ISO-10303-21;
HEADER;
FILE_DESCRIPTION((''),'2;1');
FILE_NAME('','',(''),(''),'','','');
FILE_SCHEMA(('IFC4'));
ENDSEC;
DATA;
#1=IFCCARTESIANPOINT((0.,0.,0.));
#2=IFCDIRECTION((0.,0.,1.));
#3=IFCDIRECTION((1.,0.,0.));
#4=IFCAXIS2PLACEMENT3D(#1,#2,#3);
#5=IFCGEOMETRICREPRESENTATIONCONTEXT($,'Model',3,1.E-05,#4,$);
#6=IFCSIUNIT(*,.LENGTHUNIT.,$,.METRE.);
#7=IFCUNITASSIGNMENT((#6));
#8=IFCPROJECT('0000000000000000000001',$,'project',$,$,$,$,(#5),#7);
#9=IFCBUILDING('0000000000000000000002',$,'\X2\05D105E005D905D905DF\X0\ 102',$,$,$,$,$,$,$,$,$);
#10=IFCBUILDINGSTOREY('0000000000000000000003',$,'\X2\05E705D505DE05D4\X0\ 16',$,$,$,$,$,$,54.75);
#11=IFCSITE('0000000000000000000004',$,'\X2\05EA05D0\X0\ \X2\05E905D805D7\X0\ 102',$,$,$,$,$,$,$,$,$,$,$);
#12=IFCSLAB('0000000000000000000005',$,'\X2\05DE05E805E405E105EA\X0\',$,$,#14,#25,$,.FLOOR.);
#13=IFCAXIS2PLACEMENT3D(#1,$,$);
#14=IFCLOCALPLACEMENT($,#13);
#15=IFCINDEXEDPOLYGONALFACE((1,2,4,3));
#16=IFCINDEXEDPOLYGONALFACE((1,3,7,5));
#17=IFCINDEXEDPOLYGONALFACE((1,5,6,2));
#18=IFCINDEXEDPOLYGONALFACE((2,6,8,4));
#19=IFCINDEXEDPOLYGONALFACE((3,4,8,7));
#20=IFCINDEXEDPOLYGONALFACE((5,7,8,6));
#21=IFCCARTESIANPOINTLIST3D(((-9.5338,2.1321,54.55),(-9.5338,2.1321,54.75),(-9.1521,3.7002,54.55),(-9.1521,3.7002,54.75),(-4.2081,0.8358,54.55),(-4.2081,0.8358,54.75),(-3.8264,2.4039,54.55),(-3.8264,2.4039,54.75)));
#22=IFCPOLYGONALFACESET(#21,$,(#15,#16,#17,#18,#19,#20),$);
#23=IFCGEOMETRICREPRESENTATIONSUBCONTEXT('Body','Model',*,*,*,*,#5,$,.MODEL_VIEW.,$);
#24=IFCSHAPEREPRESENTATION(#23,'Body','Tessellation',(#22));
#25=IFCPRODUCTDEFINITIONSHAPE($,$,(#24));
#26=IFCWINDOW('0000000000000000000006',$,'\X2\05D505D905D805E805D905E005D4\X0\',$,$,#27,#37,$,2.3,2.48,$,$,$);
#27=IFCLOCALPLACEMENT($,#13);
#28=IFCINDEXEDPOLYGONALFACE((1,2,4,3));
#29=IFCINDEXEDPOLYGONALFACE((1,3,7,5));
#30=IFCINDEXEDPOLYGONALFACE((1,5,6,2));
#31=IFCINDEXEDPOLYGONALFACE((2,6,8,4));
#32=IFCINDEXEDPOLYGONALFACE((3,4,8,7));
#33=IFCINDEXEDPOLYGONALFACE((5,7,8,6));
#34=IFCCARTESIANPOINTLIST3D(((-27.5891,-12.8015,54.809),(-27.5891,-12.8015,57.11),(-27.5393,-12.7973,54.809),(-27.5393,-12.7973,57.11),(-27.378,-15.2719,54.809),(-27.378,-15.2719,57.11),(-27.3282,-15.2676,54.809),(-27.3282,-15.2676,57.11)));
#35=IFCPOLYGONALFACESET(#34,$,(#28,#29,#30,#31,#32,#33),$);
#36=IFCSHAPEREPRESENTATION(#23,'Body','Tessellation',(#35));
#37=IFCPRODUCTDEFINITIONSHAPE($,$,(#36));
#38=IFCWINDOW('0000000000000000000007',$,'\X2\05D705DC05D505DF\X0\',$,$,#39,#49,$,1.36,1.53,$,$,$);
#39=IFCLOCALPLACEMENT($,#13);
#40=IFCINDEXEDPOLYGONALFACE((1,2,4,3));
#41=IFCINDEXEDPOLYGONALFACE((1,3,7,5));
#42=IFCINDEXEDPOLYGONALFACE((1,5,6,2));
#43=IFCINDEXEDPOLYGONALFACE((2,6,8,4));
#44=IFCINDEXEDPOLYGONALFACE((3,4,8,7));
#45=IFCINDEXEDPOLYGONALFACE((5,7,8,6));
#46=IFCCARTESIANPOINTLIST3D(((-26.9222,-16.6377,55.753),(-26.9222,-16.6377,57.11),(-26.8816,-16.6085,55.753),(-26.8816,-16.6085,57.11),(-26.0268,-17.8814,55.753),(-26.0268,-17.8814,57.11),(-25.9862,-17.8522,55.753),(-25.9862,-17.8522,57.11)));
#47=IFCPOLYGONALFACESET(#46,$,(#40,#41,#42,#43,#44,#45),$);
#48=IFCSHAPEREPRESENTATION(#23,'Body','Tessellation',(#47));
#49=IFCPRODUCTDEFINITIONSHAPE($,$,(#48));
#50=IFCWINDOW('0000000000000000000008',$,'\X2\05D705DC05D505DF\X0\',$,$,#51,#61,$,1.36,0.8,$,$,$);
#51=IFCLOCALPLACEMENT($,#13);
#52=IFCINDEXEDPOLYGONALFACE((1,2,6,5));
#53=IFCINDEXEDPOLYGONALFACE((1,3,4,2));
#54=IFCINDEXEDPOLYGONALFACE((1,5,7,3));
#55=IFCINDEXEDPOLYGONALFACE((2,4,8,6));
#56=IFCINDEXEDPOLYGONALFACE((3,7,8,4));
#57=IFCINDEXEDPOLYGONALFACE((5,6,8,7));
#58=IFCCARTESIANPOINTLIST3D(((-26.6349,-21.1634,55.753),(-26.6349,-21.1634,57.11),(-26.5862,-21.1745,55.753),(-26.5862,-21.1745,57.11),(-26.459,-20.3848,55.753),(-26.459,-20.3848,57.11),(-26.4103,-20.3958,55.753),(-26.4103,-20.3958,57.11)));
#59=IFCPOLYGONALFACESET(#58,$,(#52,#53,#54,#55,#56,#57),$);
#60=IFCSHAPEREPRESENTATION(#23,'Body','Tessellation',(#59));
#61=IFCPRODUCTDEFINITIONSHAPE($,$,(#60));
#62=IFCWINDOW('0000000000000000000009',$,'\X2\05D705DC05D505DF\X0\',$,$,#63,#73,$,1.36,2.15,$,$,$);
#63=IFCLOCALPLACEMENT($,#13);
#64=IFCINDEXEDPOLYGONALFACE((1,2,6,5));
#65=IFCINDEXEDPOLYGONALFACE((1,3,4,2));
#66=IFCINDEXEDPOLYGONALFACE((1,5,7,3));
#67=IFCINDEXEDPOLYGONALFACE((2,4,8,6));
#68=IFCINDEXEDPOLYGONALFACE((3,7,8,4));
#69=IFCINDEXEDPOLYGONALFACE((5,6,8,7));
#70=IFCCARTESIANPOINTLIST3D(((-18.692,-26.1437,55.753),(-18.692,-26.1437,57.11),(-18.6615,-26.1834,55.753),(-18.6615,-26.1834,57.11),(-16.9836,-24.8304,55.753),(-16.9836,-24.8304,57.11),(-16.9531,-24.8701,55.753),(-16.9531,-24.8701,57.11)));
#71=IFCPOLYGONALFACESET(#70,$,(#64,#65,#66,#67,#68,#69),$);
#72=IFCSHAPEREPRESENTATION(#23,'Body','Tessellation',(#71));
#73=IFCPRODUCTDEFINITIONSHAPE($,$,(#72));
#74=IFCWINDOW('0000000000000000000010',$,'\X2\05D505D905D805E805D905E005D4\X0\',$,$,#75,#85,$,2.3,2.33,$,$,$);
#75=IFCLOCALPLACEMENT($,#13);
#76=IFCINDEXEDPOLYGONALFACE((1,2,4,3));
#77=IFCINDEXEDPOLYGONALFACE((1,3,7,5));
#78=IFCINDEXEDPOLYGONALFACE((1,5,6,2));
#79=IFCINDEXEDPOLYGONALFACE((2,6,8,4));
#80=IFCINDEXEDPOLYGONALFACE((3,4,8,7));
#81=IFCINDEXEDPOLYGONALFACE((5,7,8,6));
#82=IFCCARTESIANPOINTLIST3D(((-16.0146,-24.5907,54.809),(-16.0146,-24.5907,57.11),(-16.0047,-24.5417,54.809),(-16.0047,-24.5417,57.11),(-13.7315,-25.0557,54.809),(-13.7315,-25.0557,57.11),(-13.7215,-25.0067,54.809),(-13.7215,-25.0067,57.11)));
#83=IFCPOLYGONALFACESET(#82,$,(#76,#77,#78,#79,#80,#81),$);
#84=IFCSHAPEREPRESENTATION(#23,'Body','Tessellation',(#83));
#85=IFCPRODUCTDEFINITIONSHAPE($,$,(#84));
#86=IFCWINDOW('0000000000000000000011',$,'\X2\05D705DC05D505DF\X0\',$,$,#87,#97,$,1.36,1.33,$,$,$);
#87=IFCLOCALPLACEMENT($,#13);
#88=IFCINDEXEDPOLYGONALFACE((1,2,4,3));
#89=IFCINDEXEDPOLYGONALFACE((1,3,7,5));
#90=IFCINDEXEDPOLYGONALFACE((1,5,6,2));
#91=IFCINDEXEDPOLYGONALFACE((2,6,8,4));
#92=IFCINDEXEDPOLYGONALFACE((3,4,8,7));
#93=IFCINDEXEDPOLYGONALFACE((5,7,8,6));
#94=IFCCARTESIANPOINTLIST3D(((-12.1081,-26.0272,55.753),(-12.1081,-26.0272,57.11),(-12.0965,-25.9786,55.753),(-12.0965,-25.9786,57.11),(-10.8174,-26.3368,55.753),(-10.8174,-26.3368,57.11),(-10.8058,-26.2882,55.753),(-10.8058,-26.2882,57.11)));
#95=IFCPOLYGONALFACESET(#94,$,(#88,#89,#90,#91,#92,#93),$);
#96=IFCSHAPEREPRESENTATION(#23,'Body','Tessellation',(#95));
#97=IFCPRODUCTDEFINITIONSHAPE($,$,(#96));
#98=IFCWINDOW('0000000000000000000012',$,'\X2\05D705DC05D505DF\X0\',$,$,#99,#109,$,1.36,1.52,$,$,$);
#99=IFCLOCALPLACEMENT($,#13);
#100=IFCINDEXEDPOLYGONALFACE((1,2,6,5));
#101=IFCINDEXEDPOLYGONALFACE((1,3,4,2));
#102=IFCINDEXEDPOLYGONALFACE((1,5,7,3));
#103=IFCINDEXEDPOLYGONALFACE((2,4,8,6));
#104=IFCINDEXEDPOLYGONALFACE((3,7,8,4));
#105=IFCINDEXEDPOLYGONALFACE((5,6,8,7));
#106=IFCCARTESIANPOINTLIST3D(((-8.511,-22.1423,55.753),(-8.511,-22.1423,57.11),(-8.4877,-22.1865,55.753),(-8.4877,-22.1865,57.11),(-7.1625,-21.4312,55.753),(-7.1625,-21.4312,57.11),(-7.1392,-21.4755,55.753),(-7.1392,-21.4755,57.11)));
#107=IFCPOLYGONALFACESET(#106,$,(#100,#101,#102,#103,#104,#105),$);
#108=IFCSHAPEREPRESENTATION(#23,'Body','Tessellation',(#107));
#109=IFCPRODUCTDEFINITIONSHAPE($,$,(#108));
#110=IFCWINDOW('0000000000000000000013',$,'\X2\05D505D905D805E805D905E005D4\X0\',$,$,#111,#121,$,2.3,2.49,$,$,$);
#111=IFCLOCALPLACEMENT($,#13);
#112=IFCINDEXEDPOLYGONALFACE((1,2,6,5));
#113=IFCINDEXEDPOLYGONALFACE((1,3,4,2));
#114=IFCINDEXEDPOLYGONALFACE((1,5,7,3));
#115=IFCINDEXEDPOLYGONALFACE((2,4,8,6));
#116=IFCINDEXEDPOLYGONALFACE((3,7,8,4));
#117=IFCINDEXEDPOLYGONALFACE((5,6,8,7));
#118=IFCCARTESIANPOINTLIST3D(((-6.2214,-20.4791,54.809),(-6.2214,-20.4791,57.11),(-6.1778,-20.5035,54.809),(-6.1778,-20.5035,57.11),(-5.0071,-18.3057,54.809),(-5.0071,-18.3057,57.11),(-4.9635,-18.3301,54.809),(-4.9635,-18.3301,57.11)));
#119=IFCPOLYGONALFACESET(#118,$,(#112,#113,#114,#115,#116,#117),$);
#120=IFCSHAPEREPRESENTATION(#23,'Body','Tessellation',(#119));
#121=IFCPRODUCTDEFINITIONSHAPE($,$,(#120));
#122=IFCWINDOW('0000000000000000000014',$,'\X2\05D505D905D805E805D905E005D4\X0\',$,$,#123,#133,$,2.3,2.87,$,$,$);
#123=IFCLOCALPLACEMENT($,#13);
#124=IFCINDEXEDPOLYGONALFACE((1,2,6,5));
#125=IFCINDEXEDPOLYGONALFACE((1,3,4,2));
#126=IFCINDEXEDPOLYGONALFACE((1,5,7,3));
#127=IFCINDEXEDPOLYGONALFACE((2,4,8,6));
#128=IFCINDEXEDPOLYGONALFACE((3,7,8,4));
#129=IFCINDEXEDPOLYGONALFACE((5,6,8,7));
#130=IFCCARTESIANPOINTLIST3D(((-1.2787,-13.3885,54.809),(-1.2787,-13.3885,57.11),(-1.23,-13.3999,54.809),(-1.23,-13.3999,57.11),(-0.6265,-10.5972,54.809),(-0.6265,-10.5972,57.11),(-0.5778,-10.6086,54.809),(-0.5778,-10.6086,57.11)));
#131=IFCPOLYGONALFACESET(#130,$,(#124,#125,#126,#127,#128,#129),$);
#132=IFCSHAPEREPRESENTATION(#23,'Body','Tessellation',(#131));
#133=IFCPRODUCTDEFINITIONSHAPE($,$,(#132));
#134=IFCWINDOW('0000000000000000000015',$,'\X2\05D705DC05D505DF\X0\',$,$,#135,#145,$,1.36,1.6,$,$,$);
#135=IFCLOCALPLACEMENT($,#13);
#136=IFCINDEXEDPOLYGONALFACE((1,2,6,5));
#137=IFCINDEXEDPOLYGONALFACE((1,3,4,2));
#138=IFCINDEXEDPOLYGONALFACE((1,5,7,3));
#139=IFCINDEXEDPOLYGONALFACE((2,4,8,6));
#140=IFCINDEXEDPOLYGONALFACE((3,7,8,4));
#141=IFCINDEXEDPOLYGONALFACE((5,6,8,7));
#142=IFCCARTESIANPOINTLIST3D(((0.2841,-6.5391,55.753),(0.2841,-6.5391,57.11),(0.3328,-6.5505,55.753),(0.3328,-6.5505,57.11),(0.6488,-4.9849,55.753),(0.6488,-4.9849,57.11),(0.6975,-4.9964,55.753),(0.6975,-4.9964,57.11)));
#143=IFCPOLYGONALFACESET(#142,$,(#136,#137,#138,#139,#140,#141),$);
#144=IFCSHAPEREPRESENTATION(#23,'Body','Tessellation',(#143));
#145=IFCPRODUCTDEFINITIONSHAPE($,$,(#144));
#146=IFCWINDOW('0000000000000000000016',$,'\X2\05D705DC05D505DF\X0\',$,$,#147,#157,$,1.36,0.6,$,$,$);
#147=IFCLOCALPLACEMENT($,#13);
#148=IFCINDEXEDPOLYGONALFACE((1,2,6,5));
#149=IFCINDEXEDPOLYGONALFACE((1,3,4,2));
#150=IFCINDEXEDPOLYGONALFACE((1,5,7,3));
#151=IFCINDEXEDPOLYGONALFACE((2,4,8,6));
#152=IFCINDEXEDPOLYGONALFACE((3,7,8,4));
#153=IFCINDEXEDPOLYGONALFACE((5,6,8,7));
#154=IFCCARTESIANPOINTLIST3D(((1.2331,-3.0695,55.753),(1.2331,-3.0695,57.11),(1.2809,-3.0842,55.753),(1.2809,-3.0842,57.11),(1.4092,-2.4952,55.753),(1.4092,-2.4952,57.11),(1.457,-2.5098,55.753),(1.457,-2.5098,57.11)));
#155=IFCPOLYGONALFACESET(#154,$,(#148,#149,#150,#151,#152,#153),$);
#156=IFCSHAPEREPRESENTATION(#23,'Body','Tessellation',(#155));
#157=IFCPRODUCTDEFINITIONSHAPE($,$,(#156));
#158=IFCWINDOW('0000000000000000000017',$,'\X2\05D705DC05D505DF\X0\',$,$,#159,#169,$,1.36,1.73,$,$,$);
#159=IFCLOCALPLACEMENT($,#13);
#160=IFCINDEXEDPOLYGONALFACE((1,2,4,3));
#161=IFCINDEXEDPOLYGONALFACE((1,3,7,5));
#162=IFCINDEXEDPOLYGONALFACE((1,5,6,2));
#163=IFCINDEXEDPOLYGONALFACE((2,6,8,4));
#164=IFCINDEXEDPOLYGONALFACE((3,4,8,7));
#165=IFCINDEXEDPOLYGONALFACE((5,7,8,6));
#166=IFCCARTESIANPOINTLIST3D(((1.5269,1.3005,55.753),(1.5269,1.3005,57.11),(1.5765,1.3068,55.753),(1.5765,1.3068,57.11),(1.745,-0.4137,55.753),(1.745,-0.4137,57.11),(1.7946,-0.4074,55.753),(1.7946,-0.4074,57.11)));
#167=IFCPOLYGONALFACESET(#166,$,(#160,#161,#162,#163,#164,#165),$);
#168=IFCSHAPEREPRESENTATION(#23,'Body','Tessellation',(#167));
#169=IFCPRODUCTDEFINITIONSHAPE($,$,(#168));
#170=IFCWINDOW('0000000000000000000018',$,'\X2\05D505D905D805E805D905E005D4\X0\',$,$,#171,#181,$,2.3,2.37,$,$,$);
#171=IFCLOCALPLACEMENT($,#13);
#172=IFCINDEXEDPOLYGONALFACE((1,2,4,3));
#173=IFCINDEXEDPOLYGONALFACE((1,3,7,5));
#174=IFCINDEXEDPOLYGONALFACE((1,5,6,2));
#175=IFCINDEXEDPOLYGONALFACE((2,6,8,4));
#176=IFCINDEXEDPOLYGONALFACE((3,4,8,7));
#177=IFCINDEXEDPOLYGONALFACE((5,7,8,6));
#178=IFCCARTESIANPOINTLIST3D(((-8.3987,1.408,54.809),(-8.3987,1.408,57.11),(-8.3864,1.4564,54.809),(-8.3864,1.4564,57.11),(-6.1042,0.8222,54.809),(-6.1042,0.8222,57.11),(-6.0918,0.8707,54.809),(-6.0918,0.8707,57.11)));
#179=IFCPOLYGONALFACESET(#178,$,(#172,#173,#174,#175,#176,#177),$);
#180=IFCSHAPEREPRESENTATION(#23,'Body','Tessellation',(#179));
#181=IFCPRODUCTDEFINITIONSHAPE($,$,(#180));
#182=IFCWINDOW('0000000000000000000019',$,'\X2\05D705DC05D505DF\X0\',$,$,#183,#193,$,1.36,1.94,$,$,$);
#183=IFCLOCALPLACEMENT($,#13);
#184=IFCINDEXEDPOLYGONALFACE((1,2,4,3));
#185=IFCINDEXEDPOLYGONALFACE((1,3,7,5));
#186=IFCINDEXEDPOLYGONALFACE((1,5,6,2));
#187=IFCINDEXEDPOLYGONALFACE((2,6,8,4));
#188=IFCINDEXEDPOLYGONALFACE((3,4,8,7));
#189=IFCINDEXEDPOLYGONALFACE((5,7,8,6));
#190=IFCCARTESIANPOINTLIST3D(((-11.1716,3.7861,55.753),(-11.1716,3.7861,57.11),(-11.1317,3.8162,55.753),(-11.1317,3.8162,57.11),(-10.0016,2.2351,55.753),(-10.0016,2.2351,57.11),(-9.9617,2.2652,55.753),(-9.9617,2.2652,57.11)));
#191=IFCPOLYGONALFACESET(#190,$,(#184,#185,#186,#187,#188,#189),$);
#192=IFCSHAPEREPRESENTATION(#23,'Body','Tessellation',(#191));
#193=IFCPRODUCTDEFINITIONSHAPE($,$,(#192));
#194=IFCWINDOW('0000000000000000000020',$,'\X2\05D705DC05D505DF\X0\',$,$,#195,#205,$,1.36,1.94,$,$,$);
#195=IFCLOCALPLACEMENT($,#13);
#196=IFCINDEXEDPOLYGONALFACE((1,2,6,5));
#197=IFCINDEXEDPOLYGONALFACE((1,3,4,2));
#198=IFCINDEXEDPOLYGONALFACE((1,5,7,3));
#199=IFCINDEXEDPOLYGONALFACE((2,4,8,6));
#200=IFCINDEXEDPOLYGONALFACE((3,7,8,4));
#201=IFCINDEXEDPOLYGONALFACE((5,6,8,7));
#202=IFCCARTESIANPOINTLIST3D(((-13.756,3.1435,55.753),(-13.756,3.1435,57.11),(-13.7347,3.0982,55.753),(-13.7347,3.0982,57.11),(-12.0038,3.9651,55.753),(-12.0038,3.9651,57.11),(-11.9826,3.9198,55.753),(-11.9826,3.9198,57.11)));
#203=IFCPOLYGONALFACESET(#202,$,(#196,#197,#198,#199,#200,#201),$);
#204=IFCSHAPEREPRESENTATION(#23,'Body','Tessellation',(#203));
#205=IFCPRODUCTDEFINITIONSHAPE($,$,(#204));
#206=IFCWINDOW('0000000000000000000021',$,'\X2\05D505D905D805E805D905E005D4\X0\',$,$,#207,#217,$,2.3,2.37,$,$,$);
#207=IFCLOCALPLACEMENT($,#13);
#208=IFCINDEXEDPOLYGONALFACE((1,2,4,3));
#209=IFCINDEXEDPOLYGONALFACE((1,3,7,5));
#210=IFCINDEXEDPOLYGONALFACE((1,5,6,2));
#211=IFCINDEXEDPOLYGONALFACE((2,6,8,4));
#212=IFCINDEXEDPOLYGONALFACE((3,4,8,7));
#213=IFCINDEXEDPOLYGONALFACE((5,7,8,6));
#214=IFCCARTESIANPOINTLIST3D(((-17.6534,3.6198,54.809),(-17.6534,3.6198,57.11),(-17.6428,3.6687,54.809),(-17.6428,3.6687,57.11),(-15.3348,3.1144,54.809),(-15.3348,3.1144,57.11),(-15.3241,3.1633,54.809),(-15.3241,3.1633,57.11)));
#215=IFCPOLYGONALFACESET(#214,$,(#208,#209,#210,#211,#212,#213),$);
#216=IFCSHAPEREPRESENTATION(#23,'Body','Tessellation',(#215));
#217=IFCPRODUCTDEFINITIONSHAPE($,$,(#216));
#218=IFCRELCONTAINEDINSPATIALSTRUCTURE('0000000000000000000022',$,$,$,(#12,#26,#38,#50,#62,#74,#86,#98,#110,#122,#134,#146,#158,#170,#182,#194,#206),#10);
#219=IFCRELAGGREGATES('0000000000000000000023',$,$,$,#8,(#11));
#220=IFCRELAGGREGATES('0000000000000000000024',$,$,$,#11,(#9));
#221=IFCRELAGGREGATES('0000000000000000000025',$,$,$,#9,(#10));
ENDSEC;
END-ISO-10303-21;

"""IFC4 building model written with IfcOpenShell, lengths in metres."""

from ifc_helpers import new_model, si_unit, frame, origin_with_axes, context, subcontext, project, spatial, polyline, outline, extrude, element, save


model = new_model("IFC4")

# Units and contexts
model_context = context("Model", 3, precision=1e-05, world=origin_with_axes())
body_context = subcontext(model_context, "Body", "Model", "MODEL_VIEW")
ifc_project = project(units=[si_unit("LENGTHUNIT", "METRE")], contexts=[model_context])

# Site, building, storey
site = spatial("IfcSite", under=ifc_project, Name="תא שטח 102")
building = spatial("IfcBuilding", under=site, Name="בניין 102")
storey = spatial("IfcBuildingStorey", under=building, Name="קומה 16", Elevation=54.75)

# Slab
element("IfcSlab", 1, inside=storey, Name="מרפסת", PredefinedType="FLOOR", context=body_context, shape_type="SweptSolid", body=[
    extrude(outline(polyline([(-9.1521, 3.7002), (-3.8264, 2.4039), (-4.2081, 0.8358), (-9.5338, 2.1321), (-9.1521, 3.7002)])), frame((0.0, 0.0, 54.55)), (0.0, 0.0, 1.0), 0.2),
])

# Windows
element("IfcWindow", 2, inside=storey, Name="ויטרינה", OverallHeight=2.3, OverallWidth=2.48, context=body_context, shape_type="SweptSolid", body=[
    extrude(outline(polyline([(-27.5891, -12.8015), (-27.378, -15.2719), (-27.3282, -15.2676), (-27.5393, -12.7973), (-27.5891, -12.8015)])), frame((0.0, 0.0, 54.809)), (0.0, 0.0, 1.0), 2.301),
])
element("IfcWindow", 3, inside=storey, Name="חלון", OverallHeight=1.36, OverallWidth=1.53, context=body_context, shape_type="SweptSolid", body=[
    extrude(outline(polyline([(-26.9222, -16.6377), (-26.0268, -17.8814), (-25.9862, -17.8522), (-26.8816, -16.6085), (-26.9222, -16.6377)])), frame((0.0, 0.0, 55.753)), (0.0, 0.0, 1.0), 1.357),
])
element("IfcWindow", 4, inside=storey, Name="חלון", OverallHeight=1.36, OverallWidth=0.8, context=body_context, shape_type="SweptSolid", body=[
    extrude(outline(polyline([(-26.459, -20.3848), (-26.6349, -21.1634), (-26.5862, -21.1745), (-26.4103, -20.3958), (-26.459, -20.3848)])), frame((0.0, 0.0, 55.753)), (0.0, 0.0, 1.0), 1.357),
])
element("IfcWindow", 5, inside=storey, Name="חלון", OverallHeight=1.36, OverallWidth=2.15, context=body_context, shape_type="SweptSolid", body=[
    extrude(outline(polyline([(-18.6615, -26.1834), (-16.9531, -24.8701), (-16.9836, -24.8304), (-18.692, -26.1437), (-18.6615, -26.1834)])), frame((0.0, 0.0, 55.753)), (0.0, 0.0, 1.0), 1.357),
])
element("IfcWindow", 6, inside=storey, Name="ויטרינה", OverallHeight=2.3, OverallWidth=2.33, context=body_context, shape_type="SweptSolid", body=[
    extrude(outline(polyline([(-16.0146, -24.5907), (-13.7315, -25.0557), (-13.7215, -25.0067), (-16.0047, -24.5417), (-16.0146, -24.5907)])), frame((0.0, 0.0, 54.809)), (0.0, 0.0, 1.0), 2.301),
])
element("IfcWindow", 7, inside=storey, Name="חלון", OverallHeight=1.36, OverallWidth=1.33, context=body_context, shape_type="SweptSolid", body=[
    extrude(outline(polyline([(-12.1081, -26.0272), (-10.8174, -26.3368), (-10.8058, -26.2882), (-12.0965, -25.9786), (-12.1081, -26.0272)])), frame((0.0, 0.0, 55.753)), (0.0, 0.0, 1.0), 1.357),
])
element("IfcWindow", 8, inside=storey, Name="חלון", OverallHeight=1.36, OverallWidth=1.52, context=body_context, shape_type="SweptSolid", body=[
    extrude(outline(polyline([(-8.4877, -22.1865), (-7.1392, -21.4755), (-7.1625, -21.4312), (-8.511, -22.1423), (-8.4877, -22.1865)])), frame((0.0, 0.0, 55.753)), (0.0, 0.0, 1.0), 1.357),
])
element("IfcWindow", 9, inside=storey, Name="ויטרינה", OverallHeight=2.3, OverallWidth=2.49, context=body_context, shape_type="SweptSolid", body=[
    extrude(outline(polyline([(-6.1778, -20.5035), (-4.9635, -18.3301), (-5.0071, -18.3057), (-6.2214, -20.4791), (-6.1778, -20.5035)])), frame((0.0, 0.0, 54.809)), (0.0, 0.0, 1.0), 2.301),
])
element("IfcWindow", 10, inside=storey, Name="ויטרינה", OverallHeight=2.3, OverallWidth=2.87, context=body_context, shape_type="SweptSolid", body=[
    extrude(outline(polyline([(-1.23, -13.3999), (-0.5778, -10.6086), (-0.6265, -10.5972), (-1.2787, -13.3885), (-1.23, -13.3999)])), frame((0.0, 0.0, 54.809)), (0.0, 0.0, 1.0), 2.301),
])
element("IfcWindow", 11, inside=storey, Name="חלון", OverallHeight=1.36, OverallWidth=1.6, context=body_context, shape_type="SweptSolid", body=[
    extrude(outline(polyline([(0.3328, -6.5505), (0.6975, -4.9964), (0.6488, -4.9849), (0.2841, -6.5391), (0.3328, -6.5505)])), frame((0.0, 0.0, 55.753)), (0.0, 0.0, 1.0), 1.357),
])
element("IfcWindow", 12, inside=storey, Name="חלון", OverallHeight=1.36, OverallWidth=0.6, context=body_context, shape_type="SweptSolid", body=[
    extrude(outline(polyline([(1.2809, -3.0842), (1.457, -2.5098), (1.4092, -2.4952), (1.2331, -3.0695), (1.2809, -3.0842)])), frame((0.0, 0.0, 55.753)), (0.0, 0.0, 1.0), 1.357),
])
element("IfcWindow", 13, inside=storey, Name="חלון", OverallHeight=1.36, OverallWidth=1.73, context=body_context, shape_type="SweptSolid", body=[
    extrude(outline(polyline([(1.7946, -0.4074), (1.5765, 1.3068), (1.5269, 1.3005), (1.745, -0.4137), (1.7946, -0.4074)])), frame((0.0, 0.0, 55.753)), (0.0, 0.0, 1.0), 1.357),
])
element("IfcWindow", 14, inside=storey, Name="ויטרינה", OverallHeight=2.3, OverallWidth=2.37, context=body_context, shape_type="SweptSolid", body=[
    extrude(outline(polyline([(-6.0918, 0.8707), (-8.3864, 1.4564), (-8.3987, 1.408), (-6.1042, 0.8222), (-6.0918, 0.8707)])), frame((0.0, 0.0, 54.809)), (0.0, 0.0, 1.0), 2.301),
])
element("IfcWindow", 15, inside=storey, Name="חלון", OverallHeight=1.36, OverallWidth=1.94, context=body_context, shape_type="SweptSolid", body=[
    extrude(outline(polyline([(-9.9617, 2.2652), (-11.1317, 3.8162), (-11.1716, 3.7861), (-10.0016, 2.2351), (-9.9617, 2.2652)])), frame((0.0, 0.0, 55.753)), (0.0, 0.0, 1.0), 1.357),
])
element("IfcWindow", 16, inside=storey, Name="חלון", OverallHeight=1.36, OverallWidth=1.94, context=body_context, shape_type="SweptSolid", body=[
    extrude(outline(polyline([(-12.0038, 3.9651), (-13.756, 3.1435), (-13.7347, 3.0982), (-11.9826, 3.9198), (-12.0038, 3.9651)])), frame((0.0, 0.0, 55.753)), (0.0, 0.0, 1.0), 1.357),
])
element("IfcWindow", 17, inside=storey, Name="ויטרינה", OverallHeight=2.3, OverallWidth=2.37, context=body_context, shape_type="SweptSolid", body=[
    extrude(outline(polyline([(-15.3241, 3.1633), (-17.6428, 3.6687), (-17.6534, 3.6198), (-15.3348, 3.1144), (-15.3241, 3.1633)])), frame((0.0, 0.0, 54.809)), (0.0, 0.0, 1.0), 2.301),
])

save(model, "model.ifc")
